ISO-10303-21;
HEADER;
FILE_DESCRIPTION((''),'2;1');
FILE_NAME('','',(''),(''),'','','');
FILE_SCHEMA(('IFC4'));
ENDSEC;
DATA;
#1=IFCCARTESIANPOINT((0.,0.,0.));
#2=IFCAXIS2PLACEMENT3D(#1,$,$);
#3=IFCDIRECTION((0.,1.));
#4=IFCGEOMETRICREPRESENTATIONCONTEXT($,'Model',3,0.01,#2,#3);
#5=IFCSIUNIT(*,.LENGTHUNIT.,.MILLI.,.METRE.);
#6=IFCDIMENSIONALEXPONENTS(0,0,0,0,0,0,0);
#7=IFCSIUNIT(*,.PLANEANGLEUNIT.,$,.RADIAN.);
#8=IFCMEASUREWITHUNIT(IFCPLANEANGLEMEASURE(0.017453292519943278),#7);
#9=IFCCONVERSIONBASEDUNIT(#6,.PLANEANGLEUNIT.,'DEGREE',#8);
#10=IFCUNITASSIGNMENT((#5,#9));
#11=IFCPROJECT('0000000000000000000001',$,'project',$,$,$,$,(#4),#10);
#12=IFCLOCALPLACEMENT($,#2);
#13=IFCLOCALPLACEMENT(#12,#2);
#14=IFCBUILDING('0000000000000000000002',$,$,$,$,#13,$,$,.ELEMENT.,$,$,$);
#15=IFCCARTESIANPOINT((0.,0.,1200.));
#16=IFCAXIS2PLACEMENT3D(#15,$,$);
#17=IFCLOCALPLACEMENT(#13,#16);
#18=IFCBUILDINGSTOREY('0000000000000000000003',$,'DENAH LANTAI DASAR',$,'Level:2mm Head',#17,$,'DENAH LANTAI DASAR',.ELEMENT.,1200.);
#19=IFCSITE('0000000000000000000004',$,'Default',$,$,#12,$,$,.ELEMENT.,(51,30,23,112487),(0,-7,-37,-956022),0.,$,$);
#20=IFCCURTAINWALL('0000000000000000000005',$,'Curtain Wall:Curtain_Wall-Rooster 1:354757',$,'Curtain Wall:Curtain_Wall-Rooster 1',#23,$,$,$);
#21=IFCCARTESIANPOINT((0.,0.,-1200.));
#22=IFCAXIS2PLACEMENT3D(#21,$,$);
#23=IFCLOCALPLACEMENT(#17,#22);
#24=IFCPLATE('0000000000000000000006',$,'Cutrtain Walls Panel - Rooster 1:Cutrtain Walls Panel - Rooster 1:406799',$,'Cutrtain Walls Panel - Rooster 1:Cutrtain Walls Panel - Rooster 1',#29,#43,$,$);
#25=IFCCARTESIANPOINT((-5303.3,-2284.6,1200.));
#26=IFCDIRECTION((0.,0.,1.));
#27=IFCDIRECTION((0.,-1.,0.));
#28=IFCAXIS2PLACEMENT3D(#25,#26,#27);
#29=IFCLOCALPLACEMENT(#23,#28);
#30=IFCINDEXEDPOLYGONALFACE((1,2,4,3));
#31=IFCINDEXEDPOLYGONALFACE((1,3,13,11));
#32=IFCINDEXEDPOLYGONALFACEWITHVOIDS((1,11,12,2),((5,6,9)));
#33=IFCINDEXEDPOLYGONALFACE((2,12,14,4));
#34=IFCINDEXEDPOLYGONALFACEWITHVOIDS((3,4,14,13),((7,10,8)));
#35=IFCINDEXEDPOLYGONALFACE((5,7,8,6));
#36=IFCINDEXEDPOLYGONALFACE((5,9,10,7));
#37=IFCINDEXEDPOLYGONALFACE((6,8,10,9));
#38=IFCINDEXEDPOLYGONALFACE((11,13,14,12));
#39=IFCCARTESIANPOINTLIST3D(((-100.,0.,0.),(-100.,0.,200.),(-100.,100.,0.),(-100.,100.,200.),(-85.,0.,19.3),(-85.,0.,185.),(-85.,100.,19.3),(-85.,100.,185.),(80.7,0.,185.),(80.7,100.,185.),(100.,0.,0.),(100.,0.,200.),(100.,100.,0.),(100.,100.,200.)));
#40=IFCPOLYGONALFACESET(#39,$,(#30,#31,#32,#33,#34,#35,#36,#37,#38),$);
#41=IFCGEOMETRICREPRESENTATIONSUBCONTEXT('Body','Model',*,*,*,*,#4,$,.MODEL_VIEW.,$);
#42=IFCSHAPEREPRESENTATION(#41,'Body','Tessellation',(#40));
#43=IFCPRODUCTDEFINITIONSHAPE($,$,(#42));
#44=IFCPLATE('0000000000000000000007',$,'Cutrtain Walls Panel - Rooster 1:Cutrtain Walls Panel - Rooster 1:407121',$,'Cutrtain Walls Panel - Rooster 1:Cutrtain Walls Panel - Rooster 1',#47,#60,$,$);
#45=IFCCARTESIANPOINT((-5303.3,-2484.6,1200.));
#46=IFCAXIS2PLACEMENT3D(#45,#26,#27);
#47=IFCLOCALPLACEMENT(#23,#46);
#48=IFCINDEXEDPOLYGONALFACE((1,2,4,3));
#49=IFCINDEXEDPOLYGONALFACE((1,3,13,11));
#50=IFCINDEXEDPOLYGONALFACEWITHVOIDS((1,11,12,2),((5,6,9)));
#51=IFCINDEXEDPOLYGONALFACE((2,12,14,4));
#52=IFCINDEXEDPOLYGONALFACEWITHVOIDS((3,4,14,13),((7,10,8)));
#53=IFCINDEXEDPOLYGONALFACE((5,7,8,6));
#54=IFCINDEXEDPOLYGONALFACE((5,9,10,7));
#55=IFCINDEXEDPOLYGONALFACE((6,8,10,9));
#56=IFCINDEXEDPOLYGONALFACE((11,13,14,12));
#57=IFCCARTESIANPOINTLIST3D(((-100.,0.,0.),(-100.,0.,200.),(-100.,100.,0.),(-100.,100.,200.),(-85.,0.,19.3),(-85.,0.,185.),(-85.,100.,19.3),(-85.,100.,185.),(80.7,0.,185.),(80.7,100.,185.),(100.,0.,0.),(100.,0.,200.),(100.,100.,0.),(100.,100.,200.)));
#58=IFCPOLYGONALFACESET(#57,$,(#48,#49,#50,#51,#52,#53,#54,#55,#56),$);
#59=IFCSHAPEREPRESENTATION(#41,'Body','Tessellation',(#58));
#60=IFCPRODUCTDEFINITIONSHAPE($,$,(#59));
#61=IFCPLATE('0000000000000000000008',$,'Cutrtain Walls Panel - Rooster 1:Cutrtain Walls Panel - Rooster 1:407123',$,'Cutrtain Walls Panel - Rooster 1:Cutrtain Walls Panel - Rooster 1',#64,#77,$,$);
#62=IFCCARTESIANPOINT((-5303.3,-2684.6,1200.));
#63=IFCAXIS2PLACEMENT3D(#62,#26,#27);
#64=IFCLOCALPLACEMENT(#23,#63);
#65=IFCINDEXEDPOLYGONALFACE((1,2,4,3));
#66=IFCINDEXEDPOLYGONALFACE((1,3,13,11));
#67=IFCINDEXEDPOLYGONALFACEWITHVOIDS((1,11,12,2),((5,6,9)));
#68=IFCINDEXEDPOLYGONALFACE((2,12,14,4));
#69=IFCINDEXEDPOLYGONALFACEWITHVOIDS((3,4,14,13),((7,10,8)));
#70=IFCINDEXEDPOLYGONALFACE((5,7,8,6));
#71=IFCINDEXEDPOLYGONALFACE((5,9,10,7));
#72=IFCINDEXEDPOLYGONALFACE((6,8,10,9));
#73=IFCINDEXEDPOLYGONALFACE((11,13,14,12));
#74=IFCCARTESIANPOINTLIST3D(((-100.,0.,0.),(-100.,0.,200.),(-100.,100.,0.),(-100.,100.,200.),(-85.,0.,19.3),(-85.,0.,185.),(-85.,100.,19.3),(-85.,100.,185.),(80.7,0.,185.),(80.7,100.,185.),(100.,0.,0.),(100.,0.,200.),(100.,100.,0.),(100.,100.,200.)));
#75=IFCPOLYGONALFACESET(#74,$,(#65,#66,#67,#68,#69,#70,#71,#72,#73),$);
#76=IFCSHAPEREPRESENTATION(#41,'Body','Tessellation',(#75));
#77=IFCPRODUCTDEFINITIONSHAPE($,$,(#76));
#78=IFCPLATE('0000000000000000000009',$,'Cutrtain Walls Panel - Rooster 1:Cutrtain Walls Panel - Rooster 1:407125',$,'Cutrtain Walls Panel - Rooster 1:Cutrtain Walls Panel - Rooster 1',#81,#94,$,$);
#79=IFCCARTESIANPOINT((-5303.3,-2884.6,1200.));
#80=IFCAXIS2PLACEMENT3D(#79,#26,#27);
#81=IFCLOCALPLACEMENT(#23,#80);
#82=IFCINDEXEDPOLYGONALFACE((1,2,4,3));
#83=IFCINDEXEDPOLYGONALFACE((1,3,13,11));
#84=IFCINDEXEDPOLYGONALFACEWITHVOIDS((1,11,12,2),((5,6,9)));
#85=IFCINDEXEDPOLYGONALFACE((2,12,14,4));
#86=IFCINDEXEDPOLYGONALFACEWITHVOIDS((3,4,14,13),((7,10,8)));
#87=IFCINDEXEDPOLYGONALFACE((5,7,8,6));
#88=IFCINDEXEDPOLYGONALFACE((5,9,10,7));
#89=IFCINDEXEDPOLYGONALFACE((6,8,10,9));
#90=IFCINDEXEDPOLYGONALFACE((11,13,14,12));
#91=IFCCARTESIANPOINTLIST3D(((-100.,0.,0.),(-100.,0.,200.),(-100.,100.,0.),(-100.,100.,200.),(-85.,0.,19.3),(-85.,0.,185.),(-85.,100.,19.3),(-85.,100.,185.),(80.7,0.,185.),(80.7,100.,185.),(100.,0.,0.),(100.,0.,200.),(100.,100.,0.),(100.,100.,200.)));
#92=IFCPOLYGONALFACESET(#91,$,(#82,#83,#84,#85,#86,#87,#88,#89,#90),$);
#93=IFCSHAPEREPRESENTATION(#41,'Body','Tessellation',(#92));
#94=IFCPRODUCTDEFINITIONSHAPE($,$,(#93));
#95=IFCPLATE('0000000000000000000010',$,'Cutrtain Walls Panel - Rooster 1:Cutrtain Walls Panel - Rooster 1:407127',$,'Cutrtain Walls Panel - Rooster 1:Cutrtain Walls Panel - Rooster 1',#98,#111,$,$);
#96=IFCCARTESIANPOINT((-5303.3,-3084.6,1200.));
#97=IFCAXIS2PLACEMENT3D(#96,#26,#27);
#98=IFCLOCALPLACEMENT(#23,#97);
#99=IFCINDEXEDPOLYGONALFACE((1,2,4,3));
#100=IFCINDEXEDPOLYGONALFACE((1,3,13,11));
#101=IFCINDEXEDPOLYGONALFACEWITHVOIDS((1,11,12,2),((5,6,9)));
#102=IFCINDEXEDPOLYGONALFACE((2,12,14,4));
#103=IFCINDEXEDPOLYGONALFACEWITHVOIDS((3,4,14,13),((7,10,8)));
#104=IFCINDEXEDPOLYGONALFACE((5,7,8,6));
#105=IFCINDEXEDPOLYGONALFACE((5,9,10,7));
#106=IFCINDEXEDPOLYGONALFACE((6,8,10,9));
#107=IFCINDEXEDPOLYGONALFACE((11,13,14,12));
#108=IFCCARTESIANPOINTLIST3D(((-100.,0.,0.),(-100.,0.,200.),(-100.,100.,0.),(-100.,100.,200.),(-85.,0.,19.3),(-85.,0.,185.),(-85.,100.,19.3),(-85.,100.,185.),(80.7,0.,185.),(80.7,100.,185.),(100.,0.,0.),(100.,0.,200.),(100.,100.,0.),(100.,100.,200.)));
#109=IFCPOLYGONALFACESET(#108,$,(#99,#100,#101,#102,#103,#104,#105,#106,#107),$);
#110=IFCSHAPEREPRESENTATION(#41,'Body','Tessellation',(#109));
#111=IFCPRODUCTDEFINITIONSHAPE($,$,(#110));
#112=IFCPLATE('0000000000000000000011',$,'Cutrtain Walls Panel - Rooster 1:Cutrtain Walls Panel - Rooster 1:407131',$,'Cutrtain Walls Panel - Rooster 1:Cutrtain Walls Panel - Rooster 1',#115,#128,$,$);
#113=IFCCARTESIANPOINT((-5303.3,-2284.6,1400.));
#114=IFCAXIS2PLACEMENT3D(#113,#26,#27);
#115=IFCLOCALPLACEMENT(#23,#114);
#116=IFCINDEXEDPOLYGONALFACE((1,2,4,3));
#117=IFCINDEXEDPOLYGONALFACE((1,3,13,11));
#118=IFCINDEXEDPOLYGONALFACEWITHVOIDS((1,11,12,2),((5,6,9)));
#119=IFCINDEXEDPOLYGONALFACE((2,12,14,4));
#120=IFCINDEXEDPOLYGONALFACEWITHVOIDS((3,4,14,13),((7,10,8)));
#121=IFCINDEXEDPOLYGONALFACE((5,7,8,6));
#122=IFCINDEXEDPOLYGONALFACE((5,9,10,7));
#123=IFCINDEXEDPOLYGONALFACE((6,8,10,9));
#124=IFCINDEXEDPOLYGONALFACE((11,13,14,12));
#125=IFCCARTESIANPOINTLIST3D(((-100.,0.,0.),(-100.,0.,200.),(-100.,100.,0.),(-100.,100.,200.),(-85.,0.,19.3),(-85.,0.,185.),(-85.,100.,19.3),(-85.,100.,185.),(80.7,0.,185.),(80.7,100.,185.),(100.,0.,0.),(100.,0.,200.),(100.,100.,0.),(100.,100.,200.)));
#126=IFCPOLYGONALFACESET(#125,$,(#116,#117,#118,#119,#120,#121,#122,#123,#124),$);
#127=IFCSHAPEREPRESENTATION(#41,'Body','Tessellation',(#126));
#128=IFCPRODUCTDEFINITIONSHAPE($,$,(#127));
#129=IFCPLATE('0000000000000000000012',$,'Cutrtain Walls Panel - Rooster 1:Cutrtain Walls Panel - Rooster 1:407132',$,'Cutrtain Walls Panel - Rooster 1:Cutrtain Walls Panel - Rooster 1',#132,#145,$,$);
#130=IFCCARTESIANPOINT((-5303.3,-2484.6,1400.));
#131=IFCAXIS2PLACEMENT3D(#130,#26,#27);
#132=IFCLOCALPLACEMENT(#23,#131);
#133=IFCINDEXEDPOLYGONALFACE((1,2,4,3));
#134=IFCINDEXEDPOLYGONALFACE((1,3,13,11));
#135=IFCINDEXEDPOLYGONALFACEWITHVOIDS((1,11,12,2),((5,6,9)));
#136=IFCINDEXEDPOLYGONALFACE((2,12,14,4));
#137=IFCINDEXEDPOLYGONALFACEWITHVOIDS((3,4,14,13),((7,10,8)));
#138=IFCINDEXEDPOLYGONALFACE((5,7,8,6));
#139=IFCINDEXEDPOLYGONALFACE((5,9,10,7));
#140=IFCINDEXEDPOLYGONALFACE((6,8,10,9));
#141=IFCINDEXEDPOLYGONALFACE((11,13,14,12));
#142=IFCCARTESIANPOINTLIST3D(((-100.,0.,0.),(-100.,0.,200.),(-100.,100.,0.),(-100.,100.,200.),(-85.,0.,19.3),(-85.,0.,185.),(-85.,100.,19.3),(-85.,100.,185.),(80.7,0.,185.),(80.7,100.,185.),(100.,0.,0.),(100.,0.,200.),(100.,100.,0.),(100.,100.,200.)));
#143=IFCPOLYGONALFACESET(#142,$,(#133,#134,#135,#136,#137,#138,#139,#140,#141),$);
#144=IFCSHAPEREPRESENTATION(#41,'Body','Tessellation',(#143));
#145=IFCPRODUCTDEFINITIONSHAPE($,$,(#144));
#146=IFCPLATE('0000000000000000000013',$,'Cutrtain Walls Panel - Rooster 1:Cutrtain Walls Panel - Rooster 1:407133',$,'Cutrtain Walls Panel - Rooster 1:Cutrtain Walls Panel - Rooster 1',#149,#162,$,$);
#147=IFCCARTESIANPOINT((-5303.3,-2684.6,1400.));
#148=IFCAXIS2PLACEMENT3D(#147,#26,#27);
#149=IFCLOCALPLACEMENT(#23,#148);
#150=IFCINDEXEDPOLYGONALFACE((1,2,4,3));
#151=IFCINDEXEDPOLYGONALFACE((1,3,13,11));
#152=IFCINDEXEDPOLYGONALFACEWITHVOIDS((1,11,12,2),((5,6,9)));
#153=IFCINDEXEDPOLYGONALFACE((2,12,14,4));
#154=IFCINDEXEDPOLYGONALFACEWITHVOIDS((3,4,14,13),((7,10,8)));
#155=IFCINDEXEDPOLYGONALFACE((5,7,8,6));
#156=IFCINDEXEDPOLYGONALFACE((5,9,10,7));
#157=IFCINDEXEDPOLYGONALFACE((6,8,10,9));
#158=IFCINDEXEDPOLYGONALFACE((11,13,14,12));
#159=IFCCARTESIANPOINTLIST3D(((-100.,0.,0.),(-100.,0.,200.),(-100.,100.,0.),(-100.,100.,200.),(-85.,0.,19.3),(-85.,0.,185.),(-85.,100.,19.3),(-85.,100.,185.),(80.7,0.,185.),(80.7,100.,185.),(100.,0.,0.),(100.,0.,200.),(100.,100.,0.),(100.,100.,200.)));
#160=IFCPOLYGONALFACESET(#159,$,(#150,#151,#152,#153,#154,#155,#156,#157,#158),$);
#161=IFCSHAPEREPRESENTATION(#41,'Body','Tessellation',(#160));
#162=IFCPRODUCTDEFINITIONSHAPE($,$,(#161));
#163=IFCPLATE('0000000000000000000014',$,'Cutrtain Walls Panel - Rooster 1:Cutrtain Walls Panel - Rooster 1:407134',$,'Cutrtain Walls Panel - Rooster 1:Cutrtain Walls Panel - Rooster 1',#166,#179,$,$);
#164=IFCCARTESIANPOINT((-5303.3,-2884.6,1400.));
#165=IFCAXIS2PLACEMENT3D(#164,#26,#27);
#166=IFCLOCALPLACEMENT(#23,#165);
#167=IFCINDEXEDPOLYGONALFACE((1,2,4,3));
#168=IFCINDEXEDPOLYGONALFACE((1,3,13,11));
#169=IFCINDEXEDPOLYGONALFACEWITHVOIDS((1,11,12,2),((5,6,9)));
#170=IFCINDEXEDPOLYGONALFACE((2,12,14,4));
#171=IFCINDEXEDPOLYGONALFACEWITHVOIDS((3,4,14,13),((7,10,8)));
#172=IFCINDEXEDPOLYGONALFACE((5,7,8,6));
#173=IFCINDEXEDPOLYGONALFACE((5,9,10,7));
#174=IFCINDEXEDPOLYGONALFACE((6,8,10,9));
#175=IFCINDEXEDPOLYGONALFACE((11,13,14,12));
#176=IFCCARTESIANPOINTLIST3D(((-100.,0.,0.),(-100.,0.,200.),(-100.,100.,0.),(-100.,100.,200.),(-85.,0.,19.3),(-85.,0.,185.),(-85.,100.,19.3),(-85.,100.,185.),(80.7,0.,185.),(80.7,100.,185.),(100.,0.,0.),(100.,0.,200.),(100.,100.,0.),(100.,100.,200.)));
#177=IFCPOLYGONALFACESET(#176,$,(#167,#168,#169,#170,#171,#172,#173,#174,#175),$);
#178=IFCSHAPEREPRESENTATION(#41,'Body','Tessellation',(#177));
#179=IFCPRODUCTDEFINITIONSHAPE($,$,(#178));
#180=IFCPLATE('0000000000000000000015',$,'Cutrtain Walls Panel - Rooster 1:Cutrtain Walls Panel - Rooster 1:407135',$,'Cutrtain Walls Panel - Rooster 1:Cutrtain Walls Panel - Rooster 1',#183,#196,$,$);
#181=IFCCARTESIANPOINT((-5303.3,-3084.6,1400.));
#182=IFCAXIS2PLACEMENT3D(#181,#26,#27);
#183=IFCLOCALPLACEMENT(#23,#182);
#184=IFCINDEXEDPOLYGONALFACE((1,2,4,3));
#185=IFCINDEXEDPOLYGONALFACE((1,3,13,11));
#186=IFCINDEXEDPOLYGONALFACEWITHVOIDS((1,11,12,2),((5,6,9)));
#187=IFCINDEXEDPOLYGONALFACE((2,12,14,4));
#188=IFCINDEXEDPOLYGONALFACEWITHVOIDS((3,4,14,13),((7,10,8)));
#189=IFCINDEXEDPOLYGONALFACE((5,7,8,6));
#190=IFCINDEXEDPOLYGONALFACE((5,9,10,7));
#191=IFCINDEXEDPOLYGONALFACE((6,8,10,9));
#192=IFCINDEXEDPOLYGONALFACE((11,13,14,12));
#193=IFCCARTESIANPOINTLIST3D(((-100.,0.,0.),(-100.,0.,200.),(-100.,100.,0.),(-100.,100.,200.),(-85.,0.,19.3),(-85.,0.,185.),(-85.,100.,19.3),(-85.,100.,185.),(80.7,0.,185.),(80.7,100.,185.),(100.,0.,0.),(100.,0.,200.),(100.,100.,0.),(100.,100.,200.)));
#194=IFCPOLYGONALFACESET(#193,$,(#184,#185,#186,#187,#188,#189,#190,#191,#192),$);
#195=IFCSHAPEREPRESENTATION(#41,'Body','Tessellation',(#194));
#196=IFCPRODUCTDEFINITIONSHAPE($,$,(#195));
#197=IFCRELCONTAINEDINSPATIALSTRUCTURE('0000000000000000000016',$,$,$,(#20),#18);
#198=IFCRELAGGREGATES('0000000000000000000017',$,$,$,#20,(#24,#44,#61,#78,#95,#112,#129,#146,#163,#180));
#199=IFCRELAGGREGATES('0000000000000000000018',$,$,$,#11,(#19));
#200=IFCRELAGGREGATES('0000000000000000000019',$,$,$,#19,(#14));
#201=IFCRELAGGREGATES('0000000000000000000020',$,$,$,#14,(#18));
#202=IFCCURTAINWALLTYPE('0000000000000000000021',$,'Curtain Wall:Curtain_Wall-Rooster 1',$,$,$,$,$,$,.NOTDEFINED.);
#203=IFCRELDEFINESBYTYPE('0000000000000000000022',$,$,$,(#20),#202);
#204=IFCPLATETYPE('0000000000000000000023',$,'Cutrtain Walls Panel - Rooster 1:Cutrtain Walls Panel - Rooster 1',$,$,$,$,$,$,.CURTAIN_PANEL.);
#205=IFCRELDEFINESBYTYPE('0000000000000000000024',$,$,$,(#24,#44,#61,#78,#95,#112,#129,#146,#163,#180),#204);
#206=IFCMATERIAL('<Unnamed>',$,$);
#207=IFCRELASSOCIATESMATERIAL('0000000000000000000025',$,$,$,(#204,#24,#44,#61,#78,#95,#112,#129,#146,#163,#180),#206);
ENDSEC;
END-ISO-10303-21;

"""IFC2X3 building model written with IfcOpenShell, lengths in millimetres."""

from ifc_helpers import new_model, entity, si_unit, converted_unit, direction, frame, origin, place, context, subcontext, project, spatial, polyline, outline, extrude, source, transform, mapped, material, type_object, type_shapes, element, aggregate, save


model = new_model("IFC2X3")

# Units and contexts
model_context = context("Model", 3, precision=0.01, world=origin(), true_north=direction((0.0, 1.0)))
body_context = subcontext(model_context, "Body", "Model", "MODEL_VIEW")
ifc_project = project(units=[si_unit("LENGTHUNIT", "METRE", prefix="MILLI"), converted_unit("PLANEANGLEUNIT", "DEGREE", entity("IfcPlaneAngleMeasure", 0.017453292519943278), si_unit("PLANEANGLEUNIT", "RADIAN"), dimensions=[0, 0, 0, 0, 0, 0, 0])], contexts=[model_context])

# Site, building, storey
site_placement = place(None, origin())
site = spatial("IfcSite", under=ifc_project, at=site_placement, Name="Default", CompositionType="ELEMENT", RefLatitude=(51, 30, 23, 112487), RefLongitude=(0, -7, -37, -956022), RefElevation=0.0)
building_placement = place(site_placement, origin())
building = spatial("IfcBuilding", under=site, at=building_placement, CompositionType="ELEMENT")
storey_placement = place(building_placement, frame((0.0, 0.0, 1200.0)))
storey = spatial("IfcBuildingStorey", under=building, at=storey_placement, Name="DENAH LANTAI DASAR", ObjectType="Level:2mm Head", LongName="DENAH LANTAI DASAR", CompositionType="ELEMENT", Elevation=1200.0)

# Curtain wall, plates
curtain_wall_type = type_object("IfcCurtainWallType", Name="Curtain Wall:Curtain_Wall-Rooster 1", PredefinedType="NOTDEFINED")
curtain_wall_1_placement = place(storey_placement, frame((0.0, 0.0, -1200.0)))
curtain_wall_1 = element("IfcCurtainWall", 1, at=curtain_wall_1_placement, inside=storey, type_object=curtain_wall_type, Name="Curtain Wall:Curtain_Wall-Rooster 1:354757", ObjectType="Curtain Wall:Curtain_Wall-Rooster 1")
ifc_material_1 = material(Name="<Unnamed>")
plate_type_1 = type_object("IfcPlateType", Name="Cutrtain Walls Panel - Rooster 1:Cutrtain Walls Panel - Rooster 1", PredefinedType="CURTAIN_PANEL", material=ifc_material_1)
shared_shape_1 = source(origin(), body_context, "Body", "SweptSolid", [
    extrude(outline(polyline([(-100.0, -100.0), (100.0, -100.0), (100.0, 100.0), (-100.0, 100.0), (-100.0, -100.0)]), holes=[polyline([(80.7, 85.0), (-85.0, -80.7), (-85.0, 85.0), (80.7, 85.0)])]), frame((0.0, 0.0, 100.0), z_axis=(0.0, 1.0, 0.0), x_axis=(0.0, 0.0, -1.0)), (0.0, 0.0, 1.0), 100.0),
])
type_shapes(plate_type_1, [shared_shape_1])
plate_1_placement = place(curtain_wall_1_placement, frame((-5303.3, -2284.6, 1200.0), z_axis=(0.0, 0.0, 1.0), x_axis=(0.0, -1.0, 0.0)))
plate_1 = element("IfcPlate", 2, at=plate_1_placement, type_object=plate_type_1, material=ifc_material_1, Name="Cutrtain Walls Panel - Rooster 1:Cutrtain Walls Panel - Rooster 1:406799", ObjectType="Cutrtain Walls Panel - Rooster 1:Cutrtain Walls Panel - Rooster 1", context=body_context, shape_type="MappedRepresentation", body=[
    mapped(shared_shape_1, transform((0.0, 0.0, 0.0), scale=1.0)),
])
plate_2_placement = place(curtain_wall_1_placement, frame((-5303.3, -2484.6, 1200.0), z_axis=(0.0, 0.0, 1.0), x_axis=(0.0, -1.0, 0.0)))
plate_2 = element("IfcPlate", 3, at=plate_2_placement, type_object=plate_type_1, material=ifc_material_1, Name="Cutrtain Walls Panel - Rooster 1:Cutrtain Walls Panel - Rooster 1:407121", ObjectType="Cutrtain Walls Panel - Rooster 1:Cutrtain Walls Panel - Rooster 1", context=body_context, shape_type="MappedRepresentation", body=[
    mapped(shared_shape_1, transform((0.0, 0.0, 0.0), scale=1.0)),
])
plate_3_placement = place(curtain_wall_1_placement, frame((-5303.3, -2684.6, 1200.0), z_axis=(0.0, 0.0, 1.0), x_axis=(0.0, -1.0, 0.0)))
plate_3 = element("IfcPlate", 4, at=plate_3_placement, type_object=plate_type_1, material=ifc_material_1, Name="Cutrtain Walls Panel - Rooster 1:Cutrtain Walls Panel - Rooster 1:407123", ObjectType="Cutrtain Walls Panel - Rooster 1:Cutrtain Walls Panel - Rooster 1", context=body_context, shape_type="MappedRepresentation", body=[
    mapped(shared_shape_1, transform((0.0, 0.0, 0.0), scale=1.0)),
])
plate_4_placement = place(curtain_wall_1_placement, frame((-5303.3, -2884.6, 1200.0), z_axis=(0.0, 0.0, 1.0), x_axis=(0.0, -1.0, 0.0)))
plate_4 = element("IfcPlate", 5, at=plate_4_placement, type_object=plate_type_1, material=ifc_material_1, Name="Cutrtain Walls Panel - Rooster 1:Cutrtain Walls Panel - Rooster 1:407125", ObjectType="Cutrtain Walls Panel - Rooster 1:Cutrtain Walls Panel - Rooster 1", context=body_context, shape_type="MappedRepresentation", body=[
    mapped(shared_shape_1, transform((0.0, 0.0, 0.0), scale=1.0)),
])
plate_5_placement = place(curtain_wall_1_placement, frame((-5303.3, -3084.6, 1200.0), z_axis=(0.0, 0.0, 1.0), x_axis=(0.0, -1.0, 0.0)))
plate_5 = element("IfcPlate", 6, at=plate_5_placement, type_object=plate_type_1, material=ifc_material_1, Name="Cutrtain Walls Panel - Rooster 1:Cutrtain Walls Panel - Rooster 1:407127", ObjectType="Cutrtain Walls Panel - Rooster 1:Cutrtain Walls Panel - Rooster 1", context=body_context, shape_type="MappedRepresentation", body=[
    mapped(shared_shape_1, transform((0.0, 0.0, 0.0), scale=1.0)),
])
plate_6_placement = place(curtain_wall_1_placement, frame((-5303.3, -2284.6, 1400.0), z_axis=(0.0, 0.0, 1.0), x_axis=(0.0, -1.0, 0.0)))
plate_6 = element("IfcPlate", 7, at=plate_6_placement, type_object=plate_type_1, material=ifc_material_1, Name="Cutrtain Walls Panel - Rooster 1:Cutrtain Walls Panel - Rooster 1:407131", ObjectType="Cutrtain Walls Panel - Rooster 1:Cutrtain Walls Panel - Rooster 1", context=body_context, shape_type="MappedRepresentation", body=[
    mapped(shared_shape_1, transform((0.0, 0.0, 0.0), scale=1.0)),
])
plate_7_placement = place(curtain_wall_1_placement, frame((-5303.3, -2484.6, 1400.0), z_axis=(0.0, 0.0, 1.0), x_axis=(0.0, -1.0, 0.0)))
plate_7 = element("IfcPlate", 8, at=plate_7_placement, type_object=plate_type_1, material=ifc_material_1, Name="Cutrtain Walls Panel - Rooster 1:Cutrtain Walls Panel - Rooster 1:407132", ObjectType="Cutrtain Walls Panel - Rooster 1:Cutrtain Walls Panel - Rooster 1", context=body_context, shape_type="MappedRepresentation", body=[
    mapped(shared_shape_1, transform((0.0, 0.0, 0.0), scale=1.0)),
])
plate_8_placement = place(curtain_wall_1_placement, frame((-5303.3, -2684.6, 1400.0), z_axis=(0.0, 0.0, 1.0), x_axis=(0.0, -1.0, 0.0)))
plate_8 = element("IfcPlate", 9, at=plate_8_placement, type_object=plate_type_1, material=ifc_material_1, Name="Cutrtain Walls Panel - Rooster 1:Cutrtain Walls Panel - Rooster 1:407133", ObjectType="Cutrtain Walls Panel - Rooster 1:Cutrtain Walls Panel - Rooster 1", context=body_context, shape_type="MappedRepresentation", body=[
    mapped(shared_shape_1, transform((0.0, 0.0, 0.0), scale=1.0)),
])
plate_9_placement = place(curtain_wall_1_placement, frame((-5303.3, -2884.6, 1400.0), z_axis=(0.0, 0.0, 1.0), x_axis=(0.0, -1.0, 0.0)))
plate_9 = element("IfcPlate", 10, at=plate_9_placement, type_object=plate_type_1, material=ifc_material_1, Name="Cutrtain Walls Panel - Rooster 1:Cutrtain Walls Panel - Rooster 1:407134", ObjectType="Cutrtain Walls Panel - Rooster 1:Cutrtain Walls Panel - Rooster 1", context=body_context, shape_type="MappedRepresentation", body=[
    mapped(shared_shape_1, transform((0.0, 0.0, 0.0), scale=1.0)),
])
plate_10_placement = place(curtain_wall_1_placement, frame((-5303.3, -3084.6, 1400.0), z_axis=(0.0, 0.0, 1.0), x_axis=(0.0, -1.0, 0.0)))
plate_10 = element("IfcPlate", 11, at=plate_10_placement, type_object=plate_type_1, material=ifc_material_1, Name="Cutrtain Walls Panel - Rooster 1:Cutrtain Walls Panel - Rooster 1:407135", ObjectType="Cutrtain Walls Panel - Rooster 1:Cutrtain Walls Panel - Rooster 1", context=body_context, shape_type="MappedRepresentation", body=[
    mapped(shared_shape_1, transform((0.0, 0.0, 0.0), scale=1.0)),
])
aggregate(curtain_wall_1, [plate_1, plate_2, plate_3, plate_4, plate_5, plate_6, plate_7, plate_8, plate_9, plate_10])

save(model, "model.ifc")
